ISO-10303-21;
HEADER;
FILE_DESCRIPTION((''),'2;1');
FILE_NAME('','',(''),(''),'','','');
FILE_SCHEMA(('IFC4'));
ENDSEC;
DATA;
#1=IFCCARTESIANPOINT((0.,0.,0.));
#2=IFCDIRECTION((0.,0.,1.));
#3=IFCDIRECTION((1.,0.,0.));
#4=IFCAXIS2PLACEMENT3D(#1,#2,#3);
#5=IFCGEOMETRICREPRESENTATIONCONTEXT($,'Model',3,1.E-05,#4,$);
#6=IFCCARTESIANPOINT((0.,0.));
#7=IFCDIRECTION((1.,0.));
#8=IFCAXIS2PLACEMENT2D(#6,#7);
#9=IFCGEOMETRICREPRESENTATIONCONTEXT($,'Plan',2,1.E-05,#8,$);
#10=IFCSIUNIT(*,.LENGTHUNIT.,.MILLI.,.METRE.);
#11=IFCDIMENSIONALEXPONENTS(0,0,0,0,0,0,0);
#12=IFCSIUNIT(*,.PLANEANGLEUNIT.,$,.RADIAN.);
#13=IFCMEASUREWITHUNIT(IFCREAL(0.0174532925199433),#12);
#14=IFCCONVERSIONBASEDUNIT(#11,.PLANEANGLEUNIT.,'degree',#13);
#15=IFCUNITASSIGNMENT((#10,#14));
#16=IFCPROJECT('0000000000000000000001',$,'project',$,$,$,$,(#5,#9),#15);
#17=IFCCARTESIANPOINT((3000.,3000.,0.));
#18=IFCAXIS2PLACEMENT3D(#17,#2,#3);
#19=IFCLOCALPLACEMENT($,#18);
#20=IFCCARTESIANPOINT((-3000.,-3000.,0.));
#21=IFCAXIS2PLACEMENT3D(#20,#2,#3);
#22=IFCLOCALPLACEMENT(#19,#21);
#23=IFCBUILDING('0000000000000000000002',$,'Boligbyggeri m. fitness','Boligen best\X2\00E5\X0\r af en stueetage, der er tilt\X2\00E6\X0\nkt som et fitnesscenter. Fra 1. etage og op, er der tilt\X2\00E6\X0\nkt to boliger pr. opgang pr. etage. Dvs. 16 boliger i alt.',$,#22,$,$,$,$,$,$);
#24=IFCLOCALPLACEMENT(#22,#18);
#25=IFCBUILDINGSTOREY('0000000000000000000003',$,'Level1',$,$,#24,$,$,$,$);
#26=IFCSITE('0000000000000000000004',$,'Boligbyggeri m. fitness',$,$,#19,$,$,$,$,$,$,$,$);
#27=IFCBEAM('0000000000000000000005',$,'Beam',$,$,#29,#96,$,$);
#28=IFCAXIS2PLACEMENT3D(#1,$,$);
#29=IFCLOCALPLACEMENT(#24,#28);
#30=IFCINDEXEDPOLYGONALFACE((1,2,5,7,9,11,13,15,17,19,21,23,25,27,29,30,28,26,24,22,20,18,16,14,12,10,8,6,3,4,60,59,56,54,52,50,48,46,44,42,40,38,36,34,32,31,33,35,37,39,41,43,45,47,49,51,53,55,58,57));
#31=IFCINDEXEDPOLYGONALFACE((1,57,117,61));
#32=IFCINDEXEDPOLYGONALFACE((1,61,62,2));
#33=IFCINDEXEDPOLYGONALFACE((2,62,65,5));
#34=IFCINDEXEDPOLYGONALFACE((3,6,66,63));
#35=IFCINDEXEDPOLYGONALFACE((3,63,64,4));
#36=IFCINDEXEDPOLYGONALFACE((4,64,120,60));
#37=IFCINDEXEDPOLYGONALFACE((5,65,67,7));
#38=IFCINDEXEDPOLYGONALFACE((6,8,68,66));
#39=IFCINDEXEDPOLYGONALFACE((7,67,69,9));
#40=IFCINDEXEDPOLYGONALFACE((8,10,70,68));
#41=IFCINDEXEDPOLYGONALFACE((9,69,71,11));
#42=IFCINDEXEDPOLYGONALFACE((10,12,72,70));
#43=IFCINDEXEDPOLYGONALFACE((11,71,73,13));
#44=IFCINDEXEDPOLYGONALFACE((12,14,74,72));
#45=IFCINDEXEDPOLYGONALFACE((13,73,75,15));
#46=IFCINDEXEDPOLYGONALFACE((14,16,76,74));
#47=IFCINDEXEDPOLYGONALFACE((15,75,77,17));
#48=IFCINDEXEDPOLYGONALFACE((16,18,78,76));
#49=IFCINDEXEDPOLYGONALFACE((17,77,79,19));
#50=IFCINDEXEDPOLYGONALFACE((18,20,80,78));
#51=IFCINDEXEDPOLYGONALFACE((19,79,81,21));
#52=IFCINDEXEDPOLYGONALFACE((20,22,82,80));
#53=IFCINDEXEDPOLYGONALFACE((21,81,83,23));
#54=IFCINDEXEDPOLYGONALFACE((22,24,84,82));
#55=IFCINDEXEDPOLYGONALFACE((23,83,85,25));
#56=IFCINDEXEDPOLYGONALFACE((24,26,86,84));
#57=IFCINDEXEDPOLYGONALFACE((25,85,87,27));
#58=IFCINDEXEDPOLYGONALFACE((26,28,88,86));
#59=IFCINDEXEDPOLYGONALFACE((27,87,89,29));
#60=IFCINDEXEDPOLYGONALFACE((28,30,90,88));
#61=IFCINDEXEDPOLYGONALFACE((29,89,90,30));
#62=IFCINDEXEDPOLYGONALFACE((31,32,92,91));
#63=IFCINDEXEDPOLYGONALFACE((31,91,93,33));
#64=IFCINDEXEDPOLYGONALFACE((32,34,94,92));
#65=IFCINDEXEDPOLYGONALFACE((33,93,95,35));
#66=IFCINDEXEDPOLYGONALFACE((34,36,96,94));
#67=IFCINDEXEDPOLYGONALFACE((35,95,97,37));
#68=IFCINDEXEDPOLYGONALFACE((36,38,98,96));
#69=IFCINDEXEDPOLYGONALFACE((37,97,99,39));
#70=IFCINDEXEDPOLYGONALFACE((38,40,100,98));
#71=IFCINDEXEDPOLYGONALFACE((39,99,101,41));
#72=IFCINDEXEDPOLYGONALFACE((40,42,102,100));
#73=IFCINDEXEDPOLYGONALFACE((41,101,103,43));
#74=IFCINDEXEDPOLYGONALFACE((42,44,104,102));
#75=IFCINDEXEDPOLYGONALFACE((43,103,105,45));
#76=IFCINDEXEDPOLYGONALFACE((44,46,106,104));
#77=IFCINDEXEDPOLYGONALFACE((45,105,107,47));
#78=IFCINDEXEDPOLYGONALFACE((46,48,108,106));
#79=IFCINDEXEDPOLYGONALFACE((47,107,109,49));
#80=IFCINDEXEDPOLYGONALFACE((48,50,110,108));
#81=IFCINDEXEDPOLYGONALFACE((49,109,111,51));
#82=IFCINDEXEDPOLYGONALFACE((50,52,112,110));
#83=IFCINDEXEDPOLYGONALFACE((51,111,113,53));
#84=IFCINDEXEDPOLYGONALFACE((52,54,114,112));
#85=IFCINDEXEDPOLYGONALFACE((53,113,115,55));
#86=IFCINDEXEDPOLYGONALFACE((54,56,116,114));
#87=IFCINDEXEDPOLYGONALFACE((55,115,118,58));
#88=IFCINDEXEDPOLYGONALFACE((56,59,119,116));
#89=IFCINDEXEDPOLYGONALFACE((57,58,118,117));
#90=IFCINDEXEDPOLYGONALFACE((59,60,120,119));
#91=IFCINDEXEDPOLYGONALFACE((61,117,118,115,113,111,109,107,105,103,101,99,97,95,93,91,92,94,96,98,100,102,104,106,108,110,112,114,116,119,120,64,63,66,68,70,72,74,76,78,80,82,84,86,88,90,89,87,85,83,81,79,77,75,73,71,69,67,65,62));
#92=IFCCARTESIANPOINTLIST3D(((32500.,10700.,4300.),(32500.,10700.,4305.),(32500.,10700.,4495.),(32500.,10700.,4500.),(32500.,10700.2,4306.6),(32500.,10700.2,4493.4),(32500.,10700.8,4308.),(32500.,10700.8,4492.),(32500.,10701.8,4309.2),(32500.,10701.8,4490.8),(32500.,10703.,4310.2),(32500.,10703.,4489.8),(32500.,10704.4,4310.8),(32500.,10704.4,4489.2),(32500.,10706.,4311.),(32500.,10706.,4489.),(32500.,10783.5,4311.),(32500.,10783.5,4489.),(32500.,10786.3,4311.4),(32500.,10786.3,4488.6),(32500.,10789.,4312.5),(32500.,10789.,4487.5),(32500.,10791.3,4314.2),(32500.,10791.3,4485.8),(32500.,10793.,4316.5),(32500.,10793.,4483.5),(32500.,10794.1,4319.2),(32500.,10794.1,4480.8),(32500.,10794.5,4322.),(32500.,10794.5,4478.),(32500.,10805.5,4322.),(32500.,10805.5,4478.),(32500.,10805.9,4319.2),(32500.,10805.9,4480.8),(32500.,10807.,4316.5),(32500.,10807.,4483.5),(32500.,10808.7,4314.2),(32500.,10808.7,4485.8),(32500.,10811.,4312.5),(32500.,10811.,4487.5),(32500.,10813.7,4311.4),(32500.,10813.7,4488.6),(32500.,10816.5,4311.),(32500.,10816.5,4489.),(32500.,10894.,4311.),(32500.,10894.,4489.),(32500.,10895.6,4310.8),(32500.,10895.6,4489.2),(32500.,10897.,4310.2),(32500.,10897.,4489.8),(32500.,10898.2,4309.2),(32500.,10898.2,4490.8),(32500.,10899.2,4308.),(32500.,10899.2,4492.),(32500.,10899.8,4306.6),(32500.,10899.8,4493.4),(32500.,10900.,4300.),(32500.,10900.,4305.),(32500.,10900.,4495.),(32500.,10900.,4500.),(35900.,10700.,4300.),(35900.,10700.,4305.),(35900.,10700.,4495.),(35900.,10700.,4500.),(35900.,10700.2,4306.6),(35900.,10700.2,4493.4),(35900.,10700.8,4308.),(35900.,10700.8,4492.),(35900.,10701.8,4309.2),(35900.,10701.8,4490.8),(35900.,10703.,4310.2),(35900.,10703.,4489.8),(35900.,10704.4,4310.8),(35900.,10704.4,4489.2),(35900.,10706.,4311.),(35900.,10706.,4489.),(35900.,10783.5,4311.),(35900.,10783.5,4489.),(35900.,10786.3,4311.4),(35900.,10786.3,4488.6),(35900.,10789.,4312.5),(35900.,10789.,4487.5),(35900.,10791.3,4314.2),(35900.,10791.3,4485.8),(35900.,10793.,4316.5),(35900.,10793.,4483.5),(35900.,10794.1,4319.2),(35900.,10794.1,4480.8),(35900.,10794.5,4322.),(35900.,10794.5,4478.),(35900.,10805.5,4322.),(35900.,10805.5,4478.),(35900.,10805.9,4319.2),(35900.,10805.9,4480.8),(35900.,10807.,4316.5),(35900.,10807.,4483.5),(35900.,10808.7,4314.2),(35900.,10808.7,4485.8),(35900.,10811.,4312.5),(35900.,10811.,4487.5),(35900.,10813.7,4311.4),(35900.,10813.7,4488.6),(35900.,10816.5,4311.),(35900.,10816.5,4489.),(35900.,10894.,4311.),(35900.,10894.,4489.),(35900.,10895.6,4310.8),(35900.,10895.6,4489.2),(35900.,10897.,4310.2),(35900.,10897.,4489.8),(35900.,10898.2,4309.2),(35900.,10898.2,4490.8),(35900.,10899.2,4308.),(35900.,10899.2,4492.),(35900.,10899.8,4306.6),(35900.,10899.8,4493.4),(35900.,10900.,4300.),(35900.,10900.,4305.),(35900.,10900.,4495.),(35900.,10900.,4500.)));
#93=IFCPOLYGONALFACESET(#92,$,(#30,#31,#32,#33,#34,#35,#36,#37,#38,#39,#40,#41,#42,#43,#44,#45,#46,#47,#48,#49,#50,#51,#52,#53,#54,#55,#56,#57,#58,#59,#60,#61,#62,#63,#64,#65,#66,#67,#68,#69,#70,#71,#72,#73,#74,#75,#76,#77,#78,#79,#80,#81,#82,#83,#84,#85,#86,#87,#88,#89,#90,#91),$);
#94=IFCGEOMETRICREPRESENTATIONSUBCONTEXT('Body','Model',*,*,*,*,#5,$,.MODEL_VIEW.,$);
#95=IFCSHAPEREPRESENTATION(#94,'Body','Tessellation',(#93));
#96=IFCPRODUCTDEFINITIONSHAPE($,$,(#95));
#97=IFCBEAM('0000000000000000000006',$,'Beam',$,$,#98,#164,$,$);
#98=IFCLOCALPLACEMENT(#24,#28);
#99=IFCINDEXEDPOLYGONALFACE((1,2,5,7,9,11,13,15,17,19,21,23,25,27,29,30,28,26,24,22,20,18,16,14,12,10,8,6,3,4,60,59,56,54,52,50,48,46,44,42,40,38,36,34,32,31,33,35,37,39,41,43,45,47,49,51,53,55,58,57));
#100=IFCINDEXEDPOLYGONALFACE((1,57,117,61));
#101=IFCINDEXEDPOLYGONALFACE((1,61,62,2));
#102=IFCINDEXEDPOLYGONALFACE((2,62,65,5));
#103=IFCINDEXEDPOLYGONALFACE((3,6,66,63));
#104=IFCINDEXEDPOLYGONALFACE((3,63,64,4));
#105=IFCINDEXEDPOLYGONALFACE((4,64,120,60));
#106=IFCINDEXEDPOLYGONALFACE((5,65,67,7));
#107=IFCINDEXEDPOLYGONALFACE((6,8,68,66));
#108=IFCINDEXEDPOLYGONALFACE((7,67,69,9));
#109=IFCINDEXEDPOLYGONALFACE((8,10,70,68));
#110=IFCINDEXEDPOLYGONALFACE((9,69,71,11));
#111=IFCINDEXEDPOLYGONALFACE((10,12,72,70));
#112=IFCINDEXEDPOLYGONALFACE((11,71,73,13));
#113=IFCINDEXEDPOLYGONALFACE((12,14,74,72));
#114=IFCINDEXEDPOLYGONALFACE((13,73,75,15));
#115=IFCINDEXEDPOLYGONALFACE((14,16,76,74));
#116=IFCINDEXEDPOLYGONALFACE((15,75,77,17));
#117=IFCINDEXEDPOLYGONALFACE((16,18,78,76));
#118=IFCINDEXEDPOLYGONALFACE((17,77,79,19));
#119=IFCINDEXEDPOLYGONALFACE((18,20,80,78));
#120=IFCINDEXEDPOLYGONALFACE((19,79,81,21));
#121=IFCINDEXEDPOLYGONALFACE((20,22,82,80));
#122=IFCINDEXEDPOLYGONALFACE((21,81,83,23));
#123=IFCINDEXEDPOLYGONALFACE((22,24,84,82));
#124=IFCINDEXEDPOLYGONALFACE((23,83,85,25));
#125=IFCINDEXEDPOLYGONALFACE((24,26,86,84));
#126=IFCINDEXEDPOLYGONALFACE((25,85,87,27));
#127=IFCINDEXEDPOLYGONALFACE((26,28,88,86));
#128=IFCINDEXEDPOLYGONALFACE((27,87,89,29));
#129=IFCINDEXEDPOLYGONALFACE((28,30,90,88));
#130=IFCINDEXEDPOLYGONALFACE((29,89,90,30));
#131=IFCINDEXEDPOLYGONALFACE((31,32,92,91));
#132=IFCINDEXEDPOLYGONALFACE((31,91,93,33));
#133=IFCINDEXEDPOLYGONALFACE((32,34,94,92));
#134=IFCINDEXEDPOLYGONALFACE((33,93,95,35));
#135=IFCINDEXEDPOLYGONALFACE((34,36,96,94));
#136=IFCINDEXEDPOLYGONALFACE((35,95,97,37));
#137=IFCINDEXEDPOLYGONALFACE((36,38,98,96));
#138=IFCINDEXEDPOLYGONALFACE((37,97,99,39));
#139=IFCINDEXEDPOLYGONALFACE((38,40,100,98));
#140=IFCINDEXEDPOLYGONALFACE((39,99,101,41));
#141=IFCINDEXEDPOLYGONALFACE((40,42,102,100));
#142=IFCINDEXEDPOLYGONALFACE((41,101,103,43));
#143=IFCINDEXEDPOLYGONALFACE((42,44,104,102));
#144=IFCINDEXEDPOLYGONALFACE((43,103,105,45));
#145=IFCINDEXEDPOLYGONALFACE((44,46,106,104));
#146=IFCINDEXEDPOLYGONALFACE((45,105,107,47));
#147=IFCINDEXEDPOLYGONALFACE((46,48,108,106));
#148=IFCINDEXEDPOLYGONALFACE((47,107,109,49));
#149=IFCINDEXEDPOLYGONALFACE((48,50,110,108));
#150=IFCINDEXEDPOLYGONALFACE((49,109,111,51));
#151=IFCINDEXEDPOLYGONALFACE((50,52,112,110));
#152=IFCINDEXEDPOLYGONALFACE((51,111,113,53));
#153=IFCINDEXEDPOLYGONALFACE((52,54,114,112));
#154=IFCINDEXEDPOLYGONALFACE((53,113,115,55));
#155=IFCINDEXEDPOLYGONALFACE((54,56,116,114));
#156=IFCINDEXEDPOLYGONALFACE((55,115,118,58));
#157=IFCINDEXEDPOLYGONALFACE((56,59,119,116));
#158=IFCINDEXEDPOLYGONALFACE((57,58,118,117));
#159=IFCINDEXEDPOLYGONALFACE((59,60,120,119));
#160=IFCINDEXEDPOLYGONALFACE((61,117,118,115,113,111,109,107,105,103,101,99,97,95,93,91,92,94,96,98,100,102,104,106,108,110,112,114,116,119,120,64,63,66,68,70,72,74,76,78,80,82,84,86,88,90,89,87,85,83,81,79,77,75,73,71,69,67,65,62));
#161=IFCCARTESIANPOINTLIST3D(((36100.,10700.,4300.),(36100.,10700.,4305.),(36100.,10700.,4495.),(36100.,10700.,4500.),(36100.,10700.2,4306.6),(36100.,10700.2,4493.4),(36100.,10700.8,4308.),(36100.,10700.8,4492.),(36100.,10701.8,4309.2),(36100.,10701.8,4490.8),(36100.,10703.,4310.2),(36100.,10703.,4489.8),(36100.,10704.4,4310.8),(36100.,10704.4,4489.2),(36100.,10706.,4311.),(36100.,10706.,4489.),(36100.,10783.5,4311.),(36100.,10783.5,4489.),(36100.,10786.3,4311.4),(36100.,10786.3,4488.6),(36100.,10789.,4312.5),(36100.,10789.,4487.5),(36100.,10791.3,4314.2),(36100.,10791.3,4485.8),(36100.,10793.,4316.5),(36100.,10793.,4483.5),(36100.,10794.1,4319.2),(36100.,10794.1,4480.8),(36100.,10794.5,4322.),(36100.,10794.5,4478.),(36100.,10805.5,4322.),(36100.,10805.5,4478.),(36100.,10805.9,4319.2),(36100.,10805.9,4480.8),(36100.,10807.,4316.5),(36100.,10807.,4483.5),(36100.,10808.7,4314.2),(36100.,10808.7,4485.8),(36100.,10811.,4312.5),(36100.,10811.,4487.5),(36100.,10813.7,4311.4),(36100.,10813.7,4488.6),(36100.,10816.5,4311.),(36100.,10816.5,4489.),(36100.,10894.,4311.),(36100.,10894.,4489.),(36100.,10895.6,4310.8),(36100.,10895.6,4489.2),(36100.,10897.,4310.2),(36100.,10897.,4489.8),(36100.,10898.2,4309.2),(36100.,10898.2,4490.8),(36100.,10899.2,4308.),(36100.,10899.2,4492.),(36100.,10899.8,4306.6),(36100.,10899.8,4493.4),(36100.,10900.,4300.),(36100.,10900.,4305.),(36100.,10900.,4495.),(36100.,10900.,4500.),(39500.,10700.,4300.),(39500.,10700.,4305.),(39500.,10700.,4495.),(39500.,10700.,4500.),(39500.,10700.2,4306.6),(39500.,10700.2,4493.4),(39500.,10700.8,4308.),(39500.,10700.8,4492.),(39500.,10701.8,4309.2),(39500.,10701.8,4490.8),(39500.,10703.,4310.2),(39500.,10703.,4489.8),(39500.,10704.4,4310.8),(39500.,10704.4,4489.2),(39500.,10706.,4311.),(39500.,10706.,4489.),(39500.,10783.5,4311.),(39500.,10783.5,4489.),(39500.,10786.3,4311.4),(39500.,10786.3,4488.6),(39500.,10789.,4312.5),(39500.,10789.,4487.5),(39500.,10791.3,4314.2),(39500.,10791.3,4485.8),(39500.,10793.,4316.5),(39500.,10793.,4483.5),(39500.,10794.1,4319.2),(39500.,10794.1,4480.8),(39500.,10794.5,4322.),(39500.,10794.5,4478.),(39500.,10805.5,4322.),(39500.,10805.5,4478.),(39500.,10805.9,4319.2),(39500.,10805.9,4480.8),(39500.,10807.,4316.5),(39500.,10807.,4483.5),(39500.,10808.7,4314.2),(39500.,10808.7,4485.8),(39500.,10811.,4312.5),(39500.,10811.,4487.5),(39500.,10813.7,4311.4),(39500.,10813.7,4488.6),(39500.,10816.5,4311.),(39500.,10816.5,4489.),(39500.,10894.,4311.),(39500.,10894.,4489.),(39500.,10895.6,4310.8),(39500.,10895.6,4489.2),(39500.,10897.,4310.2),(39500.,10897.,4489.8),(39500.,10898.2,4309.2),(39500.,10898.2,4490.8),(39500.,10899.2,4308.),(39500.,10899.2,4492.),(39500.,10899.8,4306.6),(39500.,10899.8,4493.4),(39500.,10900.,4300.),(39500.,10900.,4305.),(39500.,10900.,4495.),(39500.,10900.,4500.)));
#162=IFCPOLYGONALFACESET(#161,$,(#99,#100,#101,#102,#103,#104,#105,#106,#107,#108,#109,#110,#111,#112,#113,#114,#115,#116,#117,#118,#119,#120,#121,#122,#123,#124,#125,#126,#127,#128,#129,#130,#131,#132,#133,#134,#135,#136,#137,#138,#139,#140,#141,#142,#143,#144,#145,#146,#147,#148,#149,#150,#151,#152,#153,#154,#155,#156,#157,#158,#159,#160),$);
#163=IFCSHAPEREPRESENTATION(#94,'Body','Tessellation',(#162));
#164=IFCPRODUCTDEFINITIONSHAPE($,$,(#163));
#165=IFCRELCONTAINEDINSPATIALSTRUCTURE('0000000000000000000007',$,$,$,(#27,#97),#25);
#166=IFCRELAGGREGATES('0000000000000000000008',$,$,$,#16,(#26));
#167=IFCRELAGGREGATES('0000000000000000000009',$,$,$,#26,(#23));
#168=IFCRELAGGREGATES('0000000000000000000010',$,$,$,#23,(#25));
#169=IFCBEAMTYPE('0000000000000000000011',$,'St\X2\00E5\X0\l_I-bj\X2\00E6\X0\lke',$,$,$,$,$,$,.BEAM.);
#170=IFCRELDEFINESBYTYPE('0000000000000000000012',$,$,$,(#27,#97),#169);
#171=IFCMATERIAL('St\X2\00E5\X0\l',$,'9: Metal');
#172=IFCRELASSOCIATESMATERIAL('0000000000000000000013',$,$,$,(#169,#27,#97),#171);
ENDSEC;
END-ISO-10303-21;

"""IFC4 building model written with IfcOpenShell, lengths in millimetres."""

from ifc_helpers import new_model, entity, si_unit, converted_unit, frame, origin_with_axes, origin_2d_with_axis, place, context, subcontext, project, spatial, i_section, extrude, material, material_profile, profile_set, profile_usage, type_object, element, save


model = new_model("IFC4")

# Units and contexts
model_context = context("Model", 3, precision=1e-05, world=origin_with_axes())
plan_context = context("Plan", 2, precision=1e-05, world=origin_2d_with_axis())
body_context = subcontext(model_context, "Body", "Model", "MODEL_VIEW")
ifc_project = project(units=[si_unit("LENGTHUNIT", "METRE", prefix="MILLI"), converted_unit("PLANEANGLEUNIT", "degree", entity("IfcReal", 0.0174532925199433), si_unit("PLANEANGLEUNIT", "RADIAN"), dimensions=[0, 0, 0, 0, 0, 0, 0])], contexts=[model_context, plan_context])

# Site, building, storey
site_placement = place(None, frame((3000.0, 3000.0, 0.0), z_axis=(0.0, 0.0, 1.0), x_axis=(1.0, 0.0, 0.0)))
site = spatial("IfcSite", under=ifc_project, at=site_placement, Name="Boligbyggeri m. fitness")
building_placement = place(site_placement, frame((-3000.0, -3000.0, 0.0), z_axis=(0.0, 0.0, 1.0), x_axis=(1.0, 0.0, 0.0)))
building = spatial("IfcBuilding", under=site, at=building_placement, Name="Boligbyggeri m. fitness", Description="Boligen består af en stueetage, der er tiltænkt som et fitnesscenter. Fra 1. etage og op, er der tiltænkt to boliger pr. opgang pr. etage. Dvs. 16 boliger i alt.")
storey_placement = place(building_placement, frame((3000.0, 3000.0, 0.0), z_axis=(0.0, 0.0, 1.0), x_axis=(1.0, 0.0, 0.0)))
storey = spatial("IfcBuildingStorey", under=building, at=storey_placement, Name="Level1")

# Beams
ifc_material_1 = material(Name="Stål", Category="9: Metal")
ifc_material_profile_1 = material_profile(ifc_material_1, i_section(OverallWidth=200.0, OverallDepth=200.0, WebThickness=11.0, FlangeThickness=11.0, FilletRadius=11.0, FlangeEdgeRadius=6.0), Name="Stål", Category="9: Metal")
ifc_profile_set_1 = profile_set([ifc_material_profile_1], Name="NY_I-Profil")
beam_type = type_object("IfcBeamType", Name="Stål_I-bjælke", PredefinedType="BEAM", material=ifc_profile_set_1)
ifc_profile_usage_1 = profile_usage(ifc_profile_set_1, cardinal=7)
beam_1_placement = place(storey_placement, frame((32500.0, 10900.0, 4500.0), z_axis=(1.0, 0.0, 0.0), x_axis=(0.0, 1.0, 0.0)))
element("IfcBeam", 1, at=beam_1_placement, inside=storey, type_object=beam_type, material=ifc_profile_usage_1, Name="Beam", context=body_context, shape_type="SweptSolid", body=[
    extrude(i_section(OverallWidth=200.0, OverallDepth=200.0, WebThickness=11.0, FlangeThickness=11.0, FilletRadius=11.0, FlangeEdgeRadius=6.0), frame((-100.0, -100.0, 0.0), z_axis=(0.0, 0.0, 1.0), x_axis=(1.0, 0.0, 0.0)), (0.0, 0.0, 1.0), 3400.0),
])
ifc_profile_usage_2 = profile_usage(ifc_profile_set_1, cardinal=7)
beam_2_placement = place(storey_placement, frame((36100.0, 10900.0, 4500.0), z_axis=(1.0, 0.0, 0.0), x_axis=(0.0, 1.0, 0.0)))
element("IfcBeam", 2, at=beam_2_placement, inside=storey, type_object=beam_type, material=ifc_profile_usage_2, Name="Beam", context=body_context, shape_type="SweptSolid", body=[
    extrude(i_section(OverallWidth=200.0, OverallDepth=200.0, WebThickness=11.0, FlangeThickness=11.0, FilletRadius=11.0, FlangeEdgeRadius=6.0), frame((-100.0, -100.0, 0.0), z_axis=(0.0, 0.0, 1.0), x_axis=(1.0, 0.0, 0.0)), (0.0, 0.0, 1.0), 3400.0),
])

save(model, "model.ifc")
